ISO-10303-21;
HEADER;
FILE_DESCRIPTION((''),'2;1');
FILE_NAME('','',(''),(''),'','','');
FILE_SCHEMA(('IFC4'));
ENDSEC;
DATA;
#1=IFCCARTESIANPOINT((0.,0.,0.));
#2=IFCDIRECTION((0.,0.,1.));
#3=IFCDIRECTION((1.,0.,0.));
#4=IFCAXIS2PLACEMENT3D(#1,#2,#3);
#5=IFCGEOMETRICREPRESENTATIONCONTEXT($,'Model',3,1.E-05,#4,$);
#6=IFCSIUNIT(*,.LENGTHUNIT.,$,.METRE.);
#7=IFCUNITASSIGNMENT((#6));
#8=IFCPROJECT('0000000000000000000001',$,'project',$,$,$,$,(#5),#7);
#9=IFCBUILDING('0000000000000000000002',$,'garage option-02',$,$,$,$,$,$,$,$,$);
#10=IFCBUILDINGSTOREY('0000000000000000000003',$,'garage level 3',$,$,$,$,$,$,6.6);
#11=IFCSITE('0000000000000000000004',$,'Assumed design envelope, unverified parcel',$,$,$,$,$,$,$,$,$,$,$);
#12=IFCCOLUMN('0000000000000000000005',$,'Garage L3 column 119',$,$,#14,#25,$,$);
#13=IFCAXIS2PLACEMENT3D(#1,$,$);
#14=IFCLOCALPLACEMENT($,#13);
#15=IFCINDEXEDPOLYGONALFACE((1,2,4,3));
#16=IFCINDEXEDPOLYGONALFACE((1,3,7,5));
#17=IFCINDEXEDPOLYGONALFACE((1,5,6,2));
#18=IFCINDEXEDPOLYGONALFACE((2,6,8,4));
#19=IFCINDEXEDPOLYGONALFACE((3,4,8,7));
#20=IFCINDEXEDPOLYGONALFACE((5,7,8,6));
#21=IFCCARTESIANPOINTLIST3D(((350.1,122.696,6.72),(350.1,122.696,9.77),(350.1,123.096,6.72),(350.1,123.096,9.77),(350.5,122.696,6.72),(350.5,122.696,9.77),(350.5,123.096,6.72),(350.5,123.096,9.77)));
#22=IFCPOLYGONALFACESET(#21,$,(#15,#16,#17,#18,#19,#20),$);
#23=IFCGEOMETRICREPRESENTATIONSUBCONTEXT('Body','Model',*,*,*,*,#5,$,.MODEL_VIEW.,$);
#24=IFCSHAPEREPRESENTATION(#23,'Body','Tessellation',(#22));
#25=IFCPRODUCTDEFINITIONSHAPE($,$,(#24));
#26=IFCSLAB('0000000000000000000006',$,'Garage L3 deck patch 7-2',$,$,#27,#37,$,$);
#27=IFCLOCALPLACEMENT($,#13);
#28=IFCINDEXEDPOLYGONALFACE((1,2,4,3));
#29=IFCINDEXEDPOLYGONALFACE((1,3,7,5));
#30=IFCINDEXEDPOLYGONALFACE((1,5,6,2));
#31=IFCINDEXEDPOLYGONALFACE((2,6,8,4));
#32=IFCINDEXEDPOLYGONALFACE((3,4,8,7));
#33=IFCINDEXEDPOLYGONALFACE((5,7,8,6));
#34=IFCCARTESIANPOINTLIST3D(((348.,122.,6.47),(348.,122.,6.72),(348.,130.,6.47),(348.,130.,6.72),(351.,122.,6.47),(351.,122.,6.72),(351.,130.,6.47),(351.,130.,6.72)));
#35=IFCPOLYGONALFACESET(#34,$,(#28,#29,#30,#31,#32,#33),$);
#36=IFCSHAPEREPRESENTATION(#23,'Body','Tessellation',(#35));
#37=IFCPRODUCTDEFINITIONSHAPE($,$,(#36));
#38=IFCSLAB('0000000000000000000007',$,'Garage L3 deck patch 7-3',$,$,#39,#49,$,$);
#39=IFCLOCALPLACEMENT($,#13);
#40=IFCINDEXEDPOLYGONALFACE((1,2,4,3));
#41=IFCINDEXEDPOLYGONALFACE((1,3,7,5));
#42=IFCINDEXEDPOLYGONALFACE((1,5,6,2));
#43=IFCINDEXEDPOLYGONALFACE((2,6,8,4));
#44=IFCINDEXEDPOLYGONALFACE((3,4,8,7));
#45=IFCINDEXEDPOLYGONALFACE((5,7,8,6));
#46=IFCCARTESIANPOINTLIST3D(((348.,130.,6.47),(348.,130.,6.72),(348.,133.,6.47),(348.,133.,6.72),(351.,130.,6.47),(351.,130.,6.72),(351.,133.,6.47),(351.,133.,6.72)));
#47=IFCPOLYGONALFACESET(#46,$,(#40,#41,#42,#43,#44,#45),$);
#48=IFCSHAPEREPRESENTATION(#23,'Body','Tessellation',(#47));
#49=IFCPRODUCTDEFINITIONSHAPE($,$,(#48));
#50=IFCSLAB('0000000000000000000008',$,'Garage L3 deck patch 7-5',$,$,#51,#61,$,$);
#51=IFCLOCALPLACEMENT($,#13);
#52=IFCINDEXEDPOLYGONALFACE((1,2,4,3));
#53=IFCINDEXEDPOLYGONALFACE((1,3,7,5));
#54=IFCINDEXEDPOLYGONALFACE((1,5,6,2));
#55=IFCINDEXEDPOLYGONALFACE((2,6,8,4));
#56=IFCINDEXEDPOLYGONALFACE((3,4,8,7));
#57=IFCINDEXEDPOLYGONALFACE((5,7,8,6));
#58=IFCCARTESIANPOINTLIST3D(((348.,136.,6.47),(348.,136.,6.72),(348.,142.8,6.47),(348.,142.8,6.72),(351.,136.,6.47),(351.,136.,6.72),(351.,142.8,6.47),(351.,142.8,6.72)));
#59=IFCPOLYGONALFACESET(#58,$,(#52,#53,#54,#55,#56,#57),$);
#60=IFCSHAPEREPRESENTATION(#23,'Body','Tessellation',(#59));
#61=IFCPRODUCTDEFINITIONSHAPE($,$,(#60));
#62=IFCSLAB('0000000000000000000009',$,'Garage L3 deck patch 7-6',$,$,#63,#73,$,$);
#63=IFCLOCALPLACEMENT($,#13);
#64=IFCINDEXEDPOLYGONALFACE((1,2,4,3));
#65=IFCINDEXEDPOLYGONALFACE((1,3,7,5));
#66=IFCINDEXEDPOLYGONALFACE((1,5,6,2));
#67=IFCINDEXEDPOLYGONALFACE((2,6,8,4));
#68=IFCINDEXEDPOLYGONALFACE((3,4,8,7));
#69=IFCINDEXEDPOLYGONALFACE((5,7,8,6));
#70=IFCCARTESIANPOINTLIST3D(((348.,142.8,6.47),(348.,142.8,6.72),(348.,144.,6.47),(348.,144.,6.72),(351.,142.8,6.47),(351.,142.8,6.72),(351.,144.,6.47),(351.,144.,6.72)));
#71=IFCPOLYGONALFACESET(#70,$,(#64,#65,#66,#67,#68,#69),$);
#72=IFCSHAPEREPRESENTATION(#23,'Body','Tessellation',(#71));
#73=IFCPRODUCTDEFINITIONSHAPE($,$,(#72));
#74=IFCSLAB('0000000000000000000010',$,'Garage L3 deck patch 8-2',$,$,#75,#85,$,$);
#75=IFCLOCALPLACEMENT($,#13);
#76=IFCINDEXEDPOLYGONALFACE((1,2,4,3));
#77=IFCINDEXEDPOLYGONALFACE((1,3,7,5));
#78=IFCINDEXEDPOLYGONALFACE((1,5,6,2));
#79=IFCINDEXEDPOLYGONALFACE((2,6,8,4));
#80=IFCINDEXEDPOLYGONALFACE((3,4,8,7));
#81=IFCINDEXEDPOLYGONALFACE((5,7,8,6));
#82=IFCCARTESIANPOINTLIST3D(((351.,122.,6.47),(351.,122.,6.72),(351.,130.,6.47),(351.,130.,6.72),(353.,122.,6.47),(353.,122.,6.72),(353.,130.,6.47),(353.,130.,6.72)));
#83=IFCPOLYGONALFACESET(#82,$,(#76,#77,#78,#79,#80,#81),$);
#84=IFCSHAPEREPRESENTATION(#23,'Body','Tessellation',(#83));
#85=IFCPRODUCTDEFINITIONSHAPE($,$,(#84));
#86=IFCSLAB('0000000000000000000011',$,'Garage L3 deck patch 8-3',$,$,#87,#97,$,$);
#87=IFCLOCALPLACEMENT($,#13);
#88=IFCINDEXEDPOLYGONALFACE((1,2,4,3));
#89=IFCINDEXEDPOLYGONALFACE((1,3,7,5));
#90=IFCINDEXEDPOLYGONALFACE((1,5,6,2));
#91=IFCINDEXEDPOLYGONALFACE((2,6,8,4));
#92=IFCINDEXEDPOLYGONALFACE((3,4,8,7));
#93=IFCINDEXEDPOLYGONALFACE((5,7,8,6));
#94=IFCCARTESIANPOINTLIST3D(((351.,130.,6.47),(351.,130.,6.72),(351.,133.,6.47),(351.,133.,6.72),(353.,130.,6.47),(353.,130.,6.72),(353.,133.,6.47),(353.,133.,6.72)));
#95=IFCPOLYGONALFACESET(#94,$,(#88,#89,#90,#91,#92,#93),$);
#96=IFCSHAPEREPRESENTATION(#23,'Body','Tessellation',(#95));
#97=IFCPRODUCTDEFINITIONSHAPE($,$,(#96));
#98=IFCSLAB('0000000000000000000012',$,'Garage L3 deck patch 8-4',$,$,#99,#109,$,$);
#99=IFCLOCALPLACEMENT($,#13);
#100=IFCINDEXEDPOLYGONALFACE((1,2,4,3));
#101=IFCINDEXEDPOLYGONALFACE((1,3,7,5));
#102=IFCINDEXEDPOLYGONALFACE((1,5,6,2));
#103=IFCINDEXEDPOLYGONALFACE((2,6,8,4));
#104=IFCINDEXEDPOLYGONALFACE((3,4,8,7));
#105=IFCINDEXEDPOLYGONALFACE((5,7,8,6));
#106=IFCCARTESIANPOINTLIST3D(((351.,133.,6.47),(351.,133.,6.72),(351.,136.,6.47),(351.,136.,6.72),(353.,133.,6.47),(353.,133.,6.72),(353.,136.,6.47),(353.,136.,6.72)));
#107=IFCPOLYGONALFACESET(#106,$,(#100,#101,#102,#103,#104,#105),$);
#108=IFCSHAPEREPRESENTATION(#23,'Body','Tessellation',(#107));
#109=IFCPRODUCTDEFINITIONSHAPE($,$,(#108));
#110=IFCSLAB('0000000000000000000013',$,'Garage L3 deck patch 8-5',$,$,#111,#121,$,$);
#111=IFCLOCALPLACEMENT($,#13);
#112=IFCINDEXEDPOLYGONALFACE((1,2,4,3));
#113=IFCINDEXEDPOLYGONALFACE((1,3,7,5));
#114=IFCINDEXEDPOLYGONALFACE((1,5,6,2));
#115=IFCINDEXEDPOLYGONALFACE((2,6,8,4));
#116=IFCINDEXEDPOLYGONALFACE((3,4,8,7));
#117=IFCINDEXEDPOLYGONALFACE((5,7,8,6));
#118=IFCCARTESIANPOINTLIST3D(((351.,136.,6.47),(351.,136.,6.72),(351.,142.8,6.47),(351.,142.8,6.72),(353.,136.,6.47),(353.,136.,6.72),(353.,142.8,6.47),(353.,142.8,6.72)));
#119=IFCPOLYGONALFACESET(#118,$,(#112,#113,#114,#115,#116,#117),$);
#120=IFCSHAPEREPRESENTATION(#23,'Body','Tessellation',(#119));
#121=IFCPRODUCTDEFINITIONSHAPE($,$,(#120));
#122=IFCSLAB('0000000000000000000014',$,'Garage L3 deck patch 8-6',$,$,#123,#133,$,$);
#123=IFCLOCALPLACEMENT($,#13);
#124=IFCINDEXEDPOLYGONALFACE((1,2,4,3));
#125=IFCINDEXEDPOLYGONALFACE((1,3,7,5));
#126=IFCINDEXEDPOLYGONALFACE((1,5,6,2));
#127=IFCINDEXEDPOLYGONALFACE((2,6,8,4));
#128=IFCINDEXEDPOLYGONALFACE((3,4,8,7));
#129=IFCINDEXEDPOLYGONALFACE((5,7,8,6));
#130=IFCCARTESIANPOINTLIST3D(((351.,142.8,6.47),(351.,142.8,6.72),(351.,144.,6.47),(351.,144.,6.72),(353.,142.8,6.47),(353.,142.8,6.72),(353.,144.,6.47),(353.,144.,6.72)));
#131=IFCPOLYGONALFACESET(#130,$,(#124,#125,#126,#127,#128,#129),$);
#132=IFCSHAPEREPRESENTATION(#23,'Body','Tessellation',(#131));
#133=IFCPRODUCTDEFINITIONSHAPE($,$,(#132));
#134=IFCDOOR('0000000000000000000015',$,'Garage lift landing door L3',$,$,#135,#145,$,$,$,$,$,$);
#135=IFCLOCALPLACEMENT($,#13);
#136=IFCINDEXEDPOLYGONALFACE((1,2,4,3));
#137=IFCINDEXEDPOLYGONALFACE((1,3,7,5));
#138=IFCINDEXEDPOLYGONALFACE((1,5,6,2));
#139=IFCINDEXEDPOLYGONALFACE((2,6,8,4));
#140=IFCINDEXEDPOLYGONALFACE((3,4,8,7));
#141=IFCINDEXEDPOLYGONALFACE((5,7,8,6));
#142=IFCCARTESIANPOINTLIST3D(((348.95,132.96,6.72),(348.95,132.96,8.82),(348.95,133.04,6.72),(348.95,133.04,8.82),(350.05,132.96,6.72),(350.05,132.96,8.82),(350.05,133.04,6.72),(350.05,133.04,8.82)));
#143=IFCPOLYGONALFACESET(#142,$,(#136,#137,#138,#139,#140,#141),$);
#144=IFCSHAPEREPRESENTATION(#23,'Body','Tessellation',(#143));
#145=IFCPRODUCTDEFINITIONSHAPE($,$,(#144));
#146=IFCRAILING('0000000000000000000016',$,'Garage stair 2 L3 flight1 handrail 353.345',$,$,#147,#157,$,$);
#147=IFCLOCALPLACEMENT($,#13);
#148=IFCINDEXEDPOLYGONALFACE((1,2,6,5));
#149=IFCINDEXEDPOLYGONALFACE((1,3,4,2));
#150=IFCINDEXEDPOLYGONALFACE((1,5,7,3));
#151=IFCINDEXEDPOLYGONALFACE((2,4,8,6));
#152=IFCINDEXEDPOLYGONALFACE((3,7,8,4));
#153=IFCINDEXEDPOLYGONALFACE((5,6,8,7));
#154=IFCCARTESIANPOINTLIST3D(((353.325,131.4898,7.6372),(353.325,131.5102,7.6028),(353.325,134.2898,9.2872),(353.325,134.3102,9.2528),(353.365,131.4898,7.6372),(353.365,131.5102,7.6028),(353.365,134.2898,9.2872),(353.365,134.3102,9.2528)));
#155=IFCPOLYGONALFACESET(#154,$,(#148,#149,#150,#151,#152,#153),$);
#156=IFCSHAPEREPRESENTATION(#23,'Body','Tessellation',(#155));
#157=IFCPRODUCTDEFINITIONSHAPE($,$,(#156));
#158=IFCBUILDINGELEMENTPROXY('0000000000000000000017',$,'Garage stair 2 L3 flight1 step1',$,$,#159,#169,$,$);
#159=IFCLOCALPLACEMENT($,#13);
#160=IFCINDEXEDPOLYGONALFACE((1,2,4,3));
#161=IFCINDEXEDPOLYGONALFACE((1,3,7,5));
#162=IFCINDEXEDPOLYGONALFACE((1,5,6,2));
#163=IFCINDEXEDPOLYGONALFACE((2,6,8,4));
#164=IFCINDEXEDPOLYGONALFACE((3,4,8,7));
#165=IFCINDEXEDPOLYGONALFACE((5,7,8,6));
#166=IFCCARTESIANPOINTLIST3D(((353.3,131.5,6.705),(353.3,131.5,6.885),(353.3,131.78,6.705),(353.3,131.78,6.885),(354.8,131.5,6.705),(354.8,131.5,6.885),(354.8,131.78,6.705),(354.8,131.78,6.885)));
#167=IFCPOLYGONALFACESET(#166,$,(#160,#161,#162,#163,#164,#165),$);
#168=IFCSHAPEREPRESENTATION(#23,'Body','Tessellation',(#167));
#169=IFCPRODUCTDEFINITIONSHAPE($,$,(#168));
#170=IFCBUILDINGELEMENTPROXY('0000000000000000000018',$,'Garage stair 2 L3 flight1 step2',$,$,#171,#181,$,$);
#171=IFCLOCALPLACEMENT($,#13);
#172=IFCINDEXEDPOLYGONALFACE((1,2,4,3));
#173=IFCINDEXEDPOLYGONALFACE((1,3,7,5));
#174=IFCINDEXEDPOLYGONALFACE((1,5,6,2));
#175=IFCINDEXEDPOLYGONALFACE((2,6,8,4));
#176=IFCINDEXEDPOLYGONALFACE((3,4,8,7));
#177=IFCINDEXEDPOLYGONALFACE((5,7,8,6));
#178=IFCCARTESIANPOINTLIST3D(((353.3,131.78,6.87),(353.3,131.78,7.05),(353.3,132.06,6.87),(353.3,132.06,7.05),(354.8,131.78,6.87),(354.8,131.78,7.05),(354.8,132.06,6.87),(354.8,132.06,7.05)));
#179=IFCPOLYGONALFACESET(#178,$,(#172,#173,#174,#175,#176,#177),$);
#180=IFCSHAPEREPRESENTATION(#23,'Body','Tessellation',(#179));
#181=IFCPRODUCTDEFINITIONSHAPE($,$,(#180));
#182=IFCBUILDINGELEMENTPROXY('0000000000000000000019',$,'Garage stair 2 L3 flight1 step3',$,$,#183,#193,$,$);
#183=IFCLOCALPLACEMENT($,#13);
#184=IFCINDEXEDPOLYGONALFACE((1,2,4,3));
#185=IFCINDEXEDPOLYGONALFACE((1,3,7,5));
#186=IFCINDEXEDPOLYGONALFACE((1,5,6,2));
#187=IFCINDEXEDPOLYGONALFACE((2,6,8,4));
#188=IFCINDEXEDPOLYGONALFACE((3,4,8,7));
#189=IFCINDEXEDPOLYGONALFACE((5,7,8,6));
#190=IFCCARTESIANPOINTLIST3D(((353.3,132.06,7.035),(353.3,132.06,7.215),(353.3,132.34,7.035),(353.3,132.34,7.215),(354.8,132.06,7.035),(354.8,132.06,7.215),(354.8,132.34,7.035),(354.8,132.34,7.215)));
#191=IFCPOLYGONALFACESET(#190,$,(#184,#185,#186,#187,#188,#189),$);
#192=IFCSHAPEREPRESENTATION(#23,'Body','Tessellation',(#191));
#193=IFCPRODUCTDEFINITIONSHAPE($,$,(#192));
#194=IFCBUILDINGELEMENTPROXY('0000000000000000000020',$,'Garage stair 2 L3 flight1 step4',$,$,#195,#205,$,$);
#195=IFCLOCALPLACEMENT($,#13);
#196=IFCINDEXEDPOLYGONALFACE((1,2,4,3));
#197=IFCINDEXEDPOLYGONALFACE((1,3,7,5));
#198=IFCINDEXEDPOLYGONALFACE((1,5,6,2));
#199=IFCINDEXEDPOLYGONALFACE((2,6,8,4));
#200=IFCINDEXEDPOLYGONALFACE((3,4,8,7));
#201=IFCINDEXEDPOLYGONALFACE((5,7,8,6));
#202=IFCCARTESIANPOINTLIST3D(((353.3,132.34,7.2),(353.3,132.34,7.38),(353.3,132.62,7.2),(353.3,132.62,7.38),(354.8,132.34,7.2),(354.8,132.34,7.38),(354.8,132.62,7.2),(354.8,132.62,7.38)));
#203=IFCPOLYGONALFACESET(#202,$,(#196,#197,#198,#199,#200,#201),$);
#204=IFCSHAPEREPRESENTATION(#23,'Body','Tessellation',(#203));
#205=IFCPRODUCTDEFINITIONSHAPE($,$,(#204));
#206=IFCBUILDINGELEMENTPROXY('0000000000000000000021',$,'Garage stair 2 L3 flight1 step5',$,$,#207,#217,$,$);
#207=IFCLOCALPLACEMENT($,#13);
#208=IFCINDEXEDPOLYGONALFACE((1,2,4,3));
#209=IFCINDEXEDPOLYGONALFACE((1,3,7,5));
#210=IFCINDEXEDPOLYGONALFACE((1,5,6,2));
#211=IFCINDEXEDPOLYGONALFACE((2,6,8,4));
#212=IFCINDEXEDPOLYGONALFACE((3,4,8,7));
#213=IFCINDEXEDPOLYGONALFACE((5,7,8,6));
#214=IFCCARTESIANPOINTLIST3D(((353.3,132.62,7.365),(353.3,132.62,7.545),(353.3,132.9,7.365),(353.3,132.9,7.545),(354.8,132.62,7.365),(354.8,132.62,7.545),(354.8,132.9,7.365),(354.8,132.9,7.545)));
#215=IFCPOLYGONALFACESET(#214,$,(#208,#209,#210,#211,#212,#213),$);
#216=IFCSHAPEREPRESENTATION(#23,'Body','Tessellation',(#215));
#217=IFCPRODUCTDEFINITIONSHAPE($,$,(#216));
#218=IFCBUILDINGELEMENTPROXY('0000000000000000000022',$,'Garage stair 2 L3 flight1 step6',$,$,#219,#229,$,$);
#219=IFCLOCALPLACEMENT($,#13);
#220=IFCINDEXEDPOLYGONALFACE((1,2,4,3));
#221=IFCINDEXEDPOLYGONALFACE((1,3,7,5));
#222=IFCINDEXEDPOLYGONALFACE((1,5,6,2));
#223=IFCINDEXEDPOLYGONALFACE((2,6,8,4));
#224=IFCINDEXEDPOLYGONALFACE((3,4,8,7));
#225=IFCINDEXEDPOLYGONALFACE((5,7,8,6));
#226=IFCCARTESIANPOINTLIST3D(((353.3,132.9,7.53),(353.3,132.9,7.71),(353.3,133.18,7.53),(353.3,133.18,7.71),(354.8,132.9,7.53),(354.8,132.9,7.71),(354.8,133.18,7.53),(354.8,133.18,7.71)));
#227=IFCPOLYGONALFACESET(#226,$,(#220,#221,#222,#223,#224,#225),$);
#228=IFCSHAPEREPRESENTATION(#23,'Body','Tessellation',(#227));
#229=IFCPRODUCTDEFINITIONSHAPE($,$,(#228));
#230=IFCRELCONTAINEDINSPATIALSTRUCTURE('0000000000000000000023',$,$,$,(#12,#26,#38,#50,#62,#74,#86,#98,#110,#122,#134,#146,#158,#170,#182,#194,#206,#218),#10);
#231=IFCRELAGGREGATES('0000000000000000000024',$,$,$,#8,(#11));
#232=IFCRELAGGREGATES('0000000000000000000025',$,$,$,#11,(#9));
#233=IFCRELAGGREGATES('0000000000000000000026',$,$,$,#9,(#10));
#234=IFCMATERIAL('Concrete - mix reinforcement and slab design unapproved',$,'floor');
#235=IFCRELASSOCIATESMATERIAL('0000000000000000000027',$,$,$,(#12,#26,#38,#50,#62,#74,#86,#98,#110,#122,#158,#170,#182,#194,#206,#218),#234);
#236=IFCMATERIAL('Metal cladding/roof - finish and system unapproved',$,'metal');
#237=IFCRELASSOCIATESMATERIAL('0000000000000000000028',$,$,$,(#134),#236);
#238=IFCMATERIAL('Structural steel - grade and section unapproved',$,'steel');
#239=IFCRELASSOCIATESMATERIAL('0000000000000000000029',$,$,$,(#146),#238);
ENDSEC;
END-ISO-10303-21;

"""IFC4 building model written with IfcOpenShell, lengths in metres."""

from ifc_helpers import new_model, si_unit, frame, origin_with_axes, place, context, subcontext, project, spatial, rectangle, extrude, material, element, save


model = new_model("IFC4")

# Units and contexts
model_context = context("Model", 3, precision=1e-05, world=origin_with_axes())
body_context = subcontext(model_context, "Body", "Model", "MODEL_VIEW")
ifc_project = project(units=[si_unit("LENGTHUNIT", "METRE")], contexts=[model_context])

# Site, building, storey
site = spatial("IfcSite", under=ifc_project, Name="Assumed design envelope, unverified parcel")
building = spatial("IfcBuilding", under=site, Name="garage option-02")
storey = spatial("IfcBuildingStorey", under=building, Name="garage level 3", Elevation=6.6)

# Column
ifc_material_1 = material(Name="Concrete - mix reinforcement and slab design unapproved", Category="floor")
column_placement = place(None, frame((350.3, 122.896, 6.72), z_axis=(0.0, 0.0, 1.0), x_axis=(1.0, 0.0, 0.0)))
element("IfcColumn", 1, at=column_placement, inside=storey, material=ifc_material_1, Name="Garage L3 column 119", context=body_context, shape_type="SweptSolid", body=[
    extrude(rectangle(XDim=0.4, YDim=0.4), origin_with_axes(), (0.0, 0.0, 1.0), 3.05),
])

# Slabs
slab_1_placement = place(None, frame((349.5, 126.0, 6.47), z_axis=(0.0, 0.0, 1.0), x_axis=(1.0, 0.0, 0.0)))
element("IfcSlab", 2, at=slab_1_placement, inside=storey, material=ifc_material_1, Name="Garage L3 deck patch 7-2", context=body_context, shape_type="SweptSolid", body=[
    extrude(rectangle(XDim=3.0, YDim=8.0), origin_with_axes(), (0.0, 0.0, 1.0), 0.25),
])
slab_2_placement = place(None, frame((349.5, 131.5, 6.47), z_axis=(0.0, 0.0, 1.0), x_axis=(1.0, 0.0, 0.0)))
element("IfcSlab", 3, at=slab_2_placement, inside=storey, material=ifc_material_1, Name="Garage L3 deck patch 7-3", context=body_context, shape_type="SweptSolid", body=[
    extrude(rectangle(XDim=3.0, YDim=3.0), origin_with_axes(), (0.0, 0.0, 1.0), 0.25),
])
slab_3_placement = place(None, frame((349.5, 139.4, 6.47), z_axis=(0.0, 0.0, 1.0), x_axis=(1.0, 0.0, 0.0)))
element("IfcSlab", 4, at=slab_3_placement, inside=storey, material=ifc_material_1, Name="Garage L3 deck patch 7-5", context=body_context, shape_type="SweptSolid", body=[
    extrude(rectangle(XDim=3.0, YDim=6.8), origin_with_axes(), (0.0, 0.0, 1.0), 0.25),
])
slab_4_placement = place(None, frame((349.5, 143.4, 6.47), z_axis=(0.0, 0.0, 1.0), x_axis=(1.0, 0.0, 0.0)))
element("IfcSlab", 5, at=slab_4_placement, inside=storey, material=ifc_material_1, Name="Garage L3 deck patch 7-6", context=body_context, shape_type="SweptSolid", body=[
    extrude(rectangle(XDim=3.0, YDim=1.2), origin_with_axes(), (0.0, 0.0, 1.0), 0.25),
])
slab_5_placement = place(None, frame((352.0, 126.0, 6.47), z_axis=(0.0, 0.0, 1.0), x_axis=(1.0, 0.0, 0.0)))
element("IfcSlab", 6, at=slab_5_placement, inside=storey, material=ifc_material_1, Name="Garage L3 deck patch 8-2", context=body_context, shape_type="SweptSolid", body=[
    extrude(rectangle(XDim=2.0, YDim=8.0), origin_with_axes(), (0.0, 0.0, 1.0), 0.25),
])
for number, where, z_axis, x_axis, name in (
    (7, (352.0, 131.5, 6.47), (0.0, 0.0, 1.0), (1.0, 0.0, 0.0), "Garage L3 deck patch 8-3"),
    (8, (352.0, 134.5, 6.47), (0.0, 0.0, 1.0), (1.0, 0.0, 0.0), "Garage L3 deck patch 8-4"),
):
    element("IfcSlab", number, at=place(None, frame(where, z_axis=z_axis, x_axis=x_axis)), inside=storey, material=ifc_material_1, Name=name, context=body_context, shape_type="SweptSolid", body=[
        extrude(rectangle(XDim=2.0, YDim=3.0), origin_with_axes(), (0.0, 0.0, 1.0), 0.25),
    ])
slab_6_placement = place(None, frame((352.0, 139.4, 6.47), z_axis=(0.0, 0.0, 1.0), x_axis=(1.0, 0.0, 0.0)))
element("IfcSlab", 9, at=slab_6_placement, inside=storey, material=ifc_material_1, Name="Garage L3 deck patch 8-5", context=body_context, shape_type="SweptSolid", body=[
    extrude(rectangle(XDim=2.0, YDim=6.8), origin_with_axes(), (0.0, 0.0, 1.0), 0.25),
])
slab_7_placement = place(None, frame((352.0, 143.4, 6.47), z_axis=(0.0, 0.0, 1.0), x_axis=(1.0, 0.0, 0.0)))
element("IfcSlab", 10, at=slab_7_placement, inside=storey, material=ifc_material_1, Name="Garage L3 deck patch 8-6", context=body_context, shape_type="SweptSolid", body=[
    extrude(rectangle(XDim=2.0, YDim=1.2), origin_with_axes(), (0.0, 0.0, 1.0), 0.25),
])

# Door
ifc_material_2 = material(Name="Metal cladding/roof - finish and system unapproved", Category="metal")
door_placement = place(None, frame((349.5, 133.0, 6.72), z_axis=(0.0, 0.0, 1.0), x_axis=(1.0, 0.0, 0.0)))
element("IfcDoor", 11, at=door_placement, inside=storey, material=ifc_material_2, Name="Garage lift landing door L3", context=body_context, shape_type="SweptSolid", body=[
    extrude(rectangle(XDim=1.1, YDim=0.08), origin_with_axes(), (0.0, 0.0, 1.0), 2.1),
])

# Railing
ifc_material_3 = material(Name="Structural steel - grade and section unapproved", Category="steel")
railing_placement = place(None, frame((353.345, 131.5, 7.62), z_axis=(0.0, 0.861539, 0.507692), x_axis=(-1.0, 0.0, 0.0)))
element("IfcRailing", 12, at=railing_placement, inside=storey, material=ifc_material_3, Name="Garage stair 2 L3 flight1 handrail 353.345", context=body_context, shape_type="SweptSolid", body=[
    extrude(rectangle(XDim=0.04, YDim=0.04), origin_with_axes(), (0.0, 0.0, 1.0), 3.25),
])

# Building element proxies
for number, where, z_axis, x_axis, name in (
    (13, (354.05, 131.64, 6.705), (0.0, 0.0, 1.0), (1.0, 0.0, 0.0), "Garage stair 2 L3 flight1 step1"),
    (14, (354.05, 131.92, 6.87), (0.0, 0.0, 1.0), (1.0, 0.0, 0.0), "Garage stair 2 L3 flight1 step2"),
    (15, (354.05, 132.2, 7.035), (0.0, 0.0, 1.0), (1.0, 0.0, 0.0), "Garage stair 2 L3 flight1 step3"),
    (16, (354.05, 132.48, 7.2), (0.0, 0.0, 1.0), (1.0, 0.0, 0.0), "Garage stair 2 L3 flight1 step4"),
    (17, (354.05, 132.76, 7.365), (0.0, 0.0, 1.0), (1.0, 0.0, 0.0), "Garage stair 2 L3 flight1 step5"),
    (18, (354.05, 133.04, 7.53), (0.0, 0.0, 1.0), (1.0, 0.0, 0.0), "Garage stair 2 L3 flight1 step6"),
):
    element("IfcBuildingElementProxy", number, at=place(None, frame(where, z_axis=z_axis, x_axis=x_axis)), inside=storey, material=ifc_material_1, Name=name, context=body_context, shape_type="SweptSolid", body=[
        extrude(rectangle(XDim=1.5, YDim=0.28), origin_with_axes(), (0.0, 0.0, 1.0), 0.18),
    ])

save(model, "model.ifc")
